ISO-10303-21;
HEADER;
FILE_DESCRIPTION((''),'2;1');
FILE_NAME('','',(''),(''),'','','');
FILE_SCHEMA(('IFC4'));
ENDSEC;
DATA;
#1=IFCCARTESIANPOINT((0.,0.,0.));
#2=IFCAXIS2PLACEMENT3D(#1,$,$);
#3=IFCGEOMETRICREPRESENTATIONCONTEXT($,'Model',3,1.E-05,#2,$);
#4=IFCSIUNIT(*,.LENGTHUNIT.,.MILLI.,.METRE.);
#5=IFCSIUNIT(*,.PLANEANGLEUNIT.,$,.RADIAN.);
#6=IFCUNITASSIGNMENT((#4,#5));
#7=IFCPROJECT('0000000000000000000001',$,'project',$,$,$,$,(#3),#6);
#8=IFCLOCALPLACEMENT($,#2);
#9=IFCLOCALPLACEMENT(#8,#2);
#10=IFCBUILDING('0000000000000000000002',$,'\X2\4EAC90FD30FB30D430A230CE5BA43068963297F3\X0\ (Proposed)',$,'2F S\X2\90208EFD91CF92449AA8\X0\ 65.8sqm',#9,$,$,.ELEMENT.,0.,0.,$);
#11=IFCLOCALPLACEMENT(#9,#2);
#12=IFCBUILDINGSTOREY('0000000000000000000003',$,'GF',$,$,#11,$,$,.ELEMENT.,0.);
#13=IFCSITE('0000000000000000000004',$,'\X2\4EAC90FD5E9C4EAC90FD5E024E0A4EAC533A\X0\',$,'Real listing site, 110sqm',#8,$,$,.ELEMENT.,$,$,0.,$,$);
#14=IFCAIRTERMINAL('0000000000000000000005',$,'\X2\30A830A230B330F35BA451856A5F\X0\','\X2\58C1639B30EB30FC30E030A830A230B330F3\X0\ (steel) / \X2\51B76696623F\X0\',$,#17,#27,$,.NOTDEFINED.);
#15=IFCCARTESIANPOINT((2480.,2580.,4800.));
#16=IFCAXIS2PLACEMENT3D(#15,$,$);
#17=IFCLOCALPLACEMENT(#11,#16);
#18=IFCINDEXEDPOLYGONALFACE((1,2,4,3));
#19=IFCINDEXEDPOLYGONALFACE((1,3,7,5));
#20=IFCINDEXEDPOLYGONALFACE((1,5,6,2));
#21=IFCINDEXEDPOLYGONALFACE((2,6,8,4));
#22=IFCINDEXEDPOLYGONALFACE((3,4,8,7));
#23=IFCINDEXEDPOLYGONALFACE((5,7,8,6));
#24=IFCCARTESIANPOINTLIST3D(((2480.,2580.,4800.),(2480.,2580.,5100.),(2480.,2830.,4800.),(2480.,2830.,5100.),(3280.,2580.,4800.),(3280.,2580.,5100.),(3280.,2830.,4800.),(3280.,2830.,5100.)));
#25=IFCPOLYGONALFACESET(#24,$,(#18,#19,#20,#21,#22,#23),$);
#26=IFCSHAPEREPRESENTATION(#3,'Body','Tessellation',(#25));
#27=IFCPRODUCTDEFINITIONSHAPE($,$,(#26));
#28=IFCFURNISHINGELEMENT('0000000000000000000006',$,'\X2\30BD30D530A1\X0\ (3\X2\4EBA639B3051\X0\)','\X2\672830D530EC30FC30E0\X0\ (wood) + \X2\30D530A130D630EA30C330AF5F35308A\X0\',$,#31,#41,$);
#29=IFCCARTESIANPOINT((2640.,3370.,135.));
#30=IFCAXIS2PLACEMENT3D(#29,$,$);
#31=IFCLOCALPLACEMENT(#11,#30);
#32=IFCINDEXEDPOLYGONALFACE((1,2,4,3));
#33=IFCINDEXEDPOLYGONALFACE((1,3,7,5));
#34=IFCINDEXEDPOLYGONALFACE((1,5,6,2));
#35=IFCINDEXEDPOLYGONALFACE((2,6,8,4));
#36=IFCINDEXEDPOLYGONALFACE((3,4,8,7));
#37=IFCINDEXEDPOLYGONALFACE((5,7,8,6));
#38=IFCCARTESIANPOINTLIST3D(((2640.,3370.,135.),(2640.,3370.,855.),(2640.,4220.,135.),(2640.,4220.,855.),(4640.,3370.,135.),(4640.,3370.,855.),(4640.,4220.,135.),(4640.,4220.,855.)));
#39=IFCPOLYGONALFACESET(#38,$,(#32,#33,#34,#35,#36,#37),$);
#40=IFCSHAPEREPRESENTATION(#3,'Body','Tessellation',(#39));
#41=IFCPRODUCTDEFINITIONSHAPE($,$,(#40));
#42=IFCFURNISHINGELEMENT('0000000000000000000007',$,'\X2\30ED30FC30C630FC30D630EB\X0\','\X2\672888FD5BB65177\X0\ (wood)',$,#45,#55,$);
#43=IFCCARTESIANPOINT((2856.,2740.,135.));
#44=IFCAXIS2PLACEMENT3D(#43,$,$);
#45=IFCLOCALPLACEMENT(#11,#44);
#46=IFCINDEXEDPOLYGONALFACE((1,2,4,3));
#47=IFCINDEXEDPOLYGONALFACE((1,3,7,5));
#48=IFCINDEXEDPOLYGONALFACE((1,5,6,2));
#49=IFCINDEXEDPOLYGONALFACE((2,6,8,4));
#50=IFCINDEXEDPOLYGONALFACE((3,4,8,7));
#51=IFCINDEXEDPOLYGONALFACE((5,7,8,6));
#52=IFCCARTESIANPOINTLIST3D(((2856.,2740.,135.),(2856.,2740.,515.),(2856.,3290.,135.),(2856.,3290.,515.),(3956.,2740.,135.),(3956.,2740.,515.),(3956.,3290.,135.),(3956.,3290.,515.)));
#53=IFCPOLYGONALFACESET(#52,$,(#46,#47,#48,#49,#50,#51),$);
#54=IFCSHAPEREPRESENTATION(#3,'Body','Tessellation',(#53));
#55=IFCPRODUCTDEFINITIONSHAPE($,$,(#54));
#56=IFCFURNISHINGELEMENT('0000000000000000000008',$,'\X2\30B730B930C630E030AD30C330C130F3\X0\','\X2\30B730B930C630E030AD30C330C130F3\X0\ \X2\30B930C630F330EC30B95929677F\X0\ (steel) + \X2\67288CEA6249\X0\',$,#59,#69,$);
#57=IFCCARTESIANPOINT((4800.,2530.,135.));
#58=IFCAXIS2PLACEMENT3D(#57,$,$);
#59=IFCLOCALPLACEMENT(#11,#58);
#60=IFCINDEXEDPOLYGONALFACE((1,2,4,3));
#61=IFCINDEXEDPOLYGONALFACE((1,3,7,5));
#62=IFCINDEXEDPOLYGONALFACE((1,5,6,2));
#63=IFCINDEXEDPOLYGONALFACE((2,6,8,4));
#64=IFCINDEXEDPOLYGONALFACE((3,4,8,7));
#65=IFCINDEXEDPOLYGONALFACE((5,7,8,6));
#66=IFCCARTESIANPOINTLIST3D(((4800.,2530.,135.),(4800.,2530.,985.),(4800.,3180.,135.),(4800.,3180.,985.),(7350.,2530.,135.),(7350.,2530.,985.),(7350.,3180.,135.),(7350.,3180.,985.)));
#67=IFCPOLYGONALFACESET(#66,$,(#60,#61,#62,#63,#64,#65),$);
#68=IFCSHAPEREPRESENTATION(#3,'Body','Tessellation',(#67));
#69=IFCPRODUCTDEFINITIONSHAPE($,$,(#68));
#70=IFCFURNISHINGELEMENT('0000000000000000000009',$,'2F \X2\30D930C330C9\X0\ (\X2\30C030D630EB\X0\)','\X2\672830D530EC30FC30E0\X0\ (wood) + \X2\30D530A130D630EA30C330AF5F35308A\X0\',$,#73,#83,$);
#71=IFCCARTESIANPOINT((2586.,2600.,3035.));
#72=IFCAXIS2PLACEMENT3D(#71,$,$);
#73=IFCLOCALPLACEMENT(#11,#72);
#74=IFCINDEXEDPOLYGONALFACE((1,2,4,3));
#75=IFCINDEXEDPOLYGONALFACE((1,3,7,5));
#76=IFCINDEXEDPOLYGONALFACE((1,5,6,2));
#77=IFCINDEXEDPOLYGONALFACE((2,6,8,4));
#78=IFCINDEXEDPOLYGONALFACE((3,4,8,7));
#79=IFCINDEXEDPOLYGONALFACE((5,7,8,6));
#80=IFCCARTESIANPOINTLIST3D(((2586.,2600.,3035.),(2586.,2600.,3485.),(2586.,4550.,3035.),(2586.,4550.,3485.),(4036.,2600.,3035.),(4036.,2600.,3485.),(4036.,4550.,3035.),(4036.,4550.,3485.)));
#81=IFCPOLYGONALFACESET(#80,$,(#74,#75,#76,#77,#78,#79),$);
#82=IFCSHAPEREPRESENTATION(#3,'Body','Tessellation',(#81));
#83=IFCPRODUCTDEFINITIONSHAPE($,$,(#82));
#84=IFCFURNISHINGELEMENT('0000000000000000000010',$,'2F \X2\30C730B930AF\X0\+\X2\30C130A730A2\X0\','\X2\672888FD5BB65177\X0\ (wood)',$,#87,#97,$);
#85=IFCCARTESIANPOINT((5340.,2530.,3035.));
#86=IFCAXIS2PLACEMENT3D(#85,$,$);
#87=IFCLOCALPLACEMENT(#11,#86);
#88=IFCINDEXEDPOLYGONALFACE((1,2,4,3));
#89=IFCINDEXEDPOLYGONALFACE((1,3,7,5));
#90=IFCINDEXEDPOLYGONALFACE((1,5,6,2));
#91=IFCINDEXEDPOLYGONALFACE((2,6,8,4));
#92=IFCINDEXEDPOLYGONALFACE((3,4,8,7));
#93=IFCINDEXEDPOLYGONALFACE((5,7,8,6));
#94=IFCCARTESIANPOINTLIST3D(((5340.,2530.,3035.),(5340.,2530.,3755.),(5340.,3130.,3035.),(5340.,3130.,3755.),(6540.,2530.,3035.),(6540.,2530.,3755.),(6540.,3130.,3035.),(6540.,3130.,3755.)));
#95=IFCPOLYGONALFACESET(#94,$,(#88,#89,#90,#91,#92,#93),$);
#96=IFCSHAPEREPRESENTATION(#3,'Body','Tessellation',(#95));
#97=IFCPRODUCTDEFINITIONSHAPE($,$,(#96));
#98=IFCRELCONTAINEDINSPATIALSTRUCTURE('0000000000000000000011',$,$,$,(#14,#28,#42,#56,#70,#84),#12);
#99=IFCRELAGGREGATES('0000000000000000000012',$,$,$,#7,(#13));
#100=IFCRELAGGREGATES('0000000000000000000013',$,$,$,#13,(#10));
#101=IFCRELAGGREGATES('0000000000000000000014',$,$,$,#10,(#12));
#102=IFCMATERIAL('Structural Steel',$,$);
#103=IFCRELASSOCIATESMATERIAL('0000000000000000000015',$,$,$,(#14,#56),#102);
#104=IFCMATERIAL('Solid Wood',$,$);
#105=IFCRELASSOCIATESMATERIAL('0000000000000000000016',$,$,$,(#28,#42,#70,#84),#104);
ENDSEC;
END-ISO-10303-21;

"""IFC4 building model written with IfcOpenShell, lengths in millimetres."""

from ifc_helpers import new_model, si_unit, frame, frame_2d, origin, place, context, project, spatial, rectangle, extrude, material, element, save


model = new_model("IFC4")

# Units and contexts
model_context = context("Model", 3, precision=1e-05, world=origin())
ifc_project = project(units=[si_unit("LENGTHUNIT", "METRE", prefix="MILLI"), si_unit("PLANEANGLEUNIT", "RADIAN")], contexts=[model_context])

# Site, building, storey
site_placement = place(None, origin())
site = spatial("IfcSite", under=ifc_project, at=site_placement, Name="京都府京都市上京区", ObjectType="Real listing site, 110sqm", CompositionType="ELEMENT", RefElevation=0.0)
building_placement = place(site_placement, origin())
building = spatial("IfcBuilding", under=site, at=building_placement, Name="京都・ピアノ室と防音 (Proposed)", ObjectType="2F S造軽量鉄骨 65.8sqm", CompositionType="ELEMENT", ElevationOfRefHeight=0.0, ElevationOfTerrain=0.0)
storey_placement = place(building_placement, origin())
storey = spatial("IfcBuildingStorey", under=building, at=storey_placement, Name="GF", CompositionType="ELEMENT", Elevation=0.0)

# Shared definitions
ifc_material_1 = material(Name="Solid Wood")

# Shared definitions
ifc_material_2 = material(Name="Structural Steel")

# Air terminal
air_terminal_placement = place(storey_placement, frame((2480.0, 2580.0, 4800.0)))
element("IfcAirTerminal", 1, at=air_terminal_placement, inside=storey, material=ifc_material_2, Name="エアコン室内機", Description="壁掛ルームエアコン (steel) / 冷暖房", PredefinedType="NOTDEFINED", context=model_context, shape_type="SweptSolid", body=[
    extrude(rectangle(XDim=800.0, YDim=250.0, at=frame_2d((400.0, 125.0))), frame((2480.0, 2580.0, 4800.0)), (0.0, 0.0, 1.0), 300.0),
])

# Furnishing elements
furnishing_1_placement = place(storey_placement, frame((2640.0, 3370.0, 135.0)))
element("IfcFurnishingElement", 2, at=furnishing_1_placement, inside=storey, material=ifc_material_1, Name="ソファ (3人掛け)", Description="木フレーム (wood) + ファブリック張り", context=model_context, shape_type="SweptSolid", body=[
    extrude(rectangle(XDim=2000.0, YDim=850.0, at=frame_2d((1000.0, 425.0))), frame((2640.0, 3370.0, 135.0)), (0.0, 0.0, 1.0), 720.0),
])
furnishing_2_placement = place(storey_placement, frame((2856.0, 2740.0, 135.0)))
element("IfcFurnishingElement", 3, at=furnishing_2_placement, inside=storey, material=ifc_material_1, Name="ローテーブル", Description="木製家具 (wood)", context=model_context, shape_type="SweptSolid", body=[
    extrude(rectangle(XDim=1100.0, YDim=550.0, at=frame_2d((550.0, 275.0))), frame((2856.0, 2740.0, 135.0)), (0.0, 0.0, 1.0), 380.0),
])
furnishing_3_placement = place(storey_placement, frame((4800.0, 2530.0, 135.0)))
element("IfcFurnishingElement", 4, at=furnishing_3_placement, inside=storey, material=ifc_material_2, Name="システムキッチン", Description="システムキッチン ステンレス天板 (steel) + 木質扉", context=model_context, shape_type="SweptSolid", body=[
    extrude(rectangle(XDim=2550.0, YDim=650.0, at=frame_2d((1275.0, 325.0))), frame((4800.0, 2530.0, 135.0)), (0.0, 0.0, 1.0), 850.0),
])
furnishing_4_placement = place(storey_placement, frame((2586.0, 2600.0, 3035.0)))
element("IfcFurnishingElement", 5, at=furnishing_4_placement, inside=storey, material=ifc_material_1, Name="2F ベッド (ダブル)", Description="木フレーム (wood) + ファブリック張り", context=model_context, shape_type="SweptSolid", body=[
    extrude(rectangle(XDim=1450.0, YDim=1950.0, at=frame_2d((725.0, 975.0))), frame((2586.0, 2600.0, 3035.0)), (0.0, 0.0, 1.0), 450.0),
])
furnishing_5_placement = place(storey_placement, frame((5340.0, 2530.0, 3035.0)))
element("IfcFurnishingElement", 6, at=furnishing_5_placement, inside=storey, material=ifc_material_1, Name="2F デスク+チェア", Description="木製家具 (wood)", context=model_context, shape_type="SweptSolid", body=[
    extrude(rectangle(XDim=1200.0, YDim=600.0, at=frame_2d((600.0, 300.0))), frame((5340.0, 2530.0, 3035.0)), (0.0, 0.0, 1.0), 720.0),
])

save(model, "model.ifc")
